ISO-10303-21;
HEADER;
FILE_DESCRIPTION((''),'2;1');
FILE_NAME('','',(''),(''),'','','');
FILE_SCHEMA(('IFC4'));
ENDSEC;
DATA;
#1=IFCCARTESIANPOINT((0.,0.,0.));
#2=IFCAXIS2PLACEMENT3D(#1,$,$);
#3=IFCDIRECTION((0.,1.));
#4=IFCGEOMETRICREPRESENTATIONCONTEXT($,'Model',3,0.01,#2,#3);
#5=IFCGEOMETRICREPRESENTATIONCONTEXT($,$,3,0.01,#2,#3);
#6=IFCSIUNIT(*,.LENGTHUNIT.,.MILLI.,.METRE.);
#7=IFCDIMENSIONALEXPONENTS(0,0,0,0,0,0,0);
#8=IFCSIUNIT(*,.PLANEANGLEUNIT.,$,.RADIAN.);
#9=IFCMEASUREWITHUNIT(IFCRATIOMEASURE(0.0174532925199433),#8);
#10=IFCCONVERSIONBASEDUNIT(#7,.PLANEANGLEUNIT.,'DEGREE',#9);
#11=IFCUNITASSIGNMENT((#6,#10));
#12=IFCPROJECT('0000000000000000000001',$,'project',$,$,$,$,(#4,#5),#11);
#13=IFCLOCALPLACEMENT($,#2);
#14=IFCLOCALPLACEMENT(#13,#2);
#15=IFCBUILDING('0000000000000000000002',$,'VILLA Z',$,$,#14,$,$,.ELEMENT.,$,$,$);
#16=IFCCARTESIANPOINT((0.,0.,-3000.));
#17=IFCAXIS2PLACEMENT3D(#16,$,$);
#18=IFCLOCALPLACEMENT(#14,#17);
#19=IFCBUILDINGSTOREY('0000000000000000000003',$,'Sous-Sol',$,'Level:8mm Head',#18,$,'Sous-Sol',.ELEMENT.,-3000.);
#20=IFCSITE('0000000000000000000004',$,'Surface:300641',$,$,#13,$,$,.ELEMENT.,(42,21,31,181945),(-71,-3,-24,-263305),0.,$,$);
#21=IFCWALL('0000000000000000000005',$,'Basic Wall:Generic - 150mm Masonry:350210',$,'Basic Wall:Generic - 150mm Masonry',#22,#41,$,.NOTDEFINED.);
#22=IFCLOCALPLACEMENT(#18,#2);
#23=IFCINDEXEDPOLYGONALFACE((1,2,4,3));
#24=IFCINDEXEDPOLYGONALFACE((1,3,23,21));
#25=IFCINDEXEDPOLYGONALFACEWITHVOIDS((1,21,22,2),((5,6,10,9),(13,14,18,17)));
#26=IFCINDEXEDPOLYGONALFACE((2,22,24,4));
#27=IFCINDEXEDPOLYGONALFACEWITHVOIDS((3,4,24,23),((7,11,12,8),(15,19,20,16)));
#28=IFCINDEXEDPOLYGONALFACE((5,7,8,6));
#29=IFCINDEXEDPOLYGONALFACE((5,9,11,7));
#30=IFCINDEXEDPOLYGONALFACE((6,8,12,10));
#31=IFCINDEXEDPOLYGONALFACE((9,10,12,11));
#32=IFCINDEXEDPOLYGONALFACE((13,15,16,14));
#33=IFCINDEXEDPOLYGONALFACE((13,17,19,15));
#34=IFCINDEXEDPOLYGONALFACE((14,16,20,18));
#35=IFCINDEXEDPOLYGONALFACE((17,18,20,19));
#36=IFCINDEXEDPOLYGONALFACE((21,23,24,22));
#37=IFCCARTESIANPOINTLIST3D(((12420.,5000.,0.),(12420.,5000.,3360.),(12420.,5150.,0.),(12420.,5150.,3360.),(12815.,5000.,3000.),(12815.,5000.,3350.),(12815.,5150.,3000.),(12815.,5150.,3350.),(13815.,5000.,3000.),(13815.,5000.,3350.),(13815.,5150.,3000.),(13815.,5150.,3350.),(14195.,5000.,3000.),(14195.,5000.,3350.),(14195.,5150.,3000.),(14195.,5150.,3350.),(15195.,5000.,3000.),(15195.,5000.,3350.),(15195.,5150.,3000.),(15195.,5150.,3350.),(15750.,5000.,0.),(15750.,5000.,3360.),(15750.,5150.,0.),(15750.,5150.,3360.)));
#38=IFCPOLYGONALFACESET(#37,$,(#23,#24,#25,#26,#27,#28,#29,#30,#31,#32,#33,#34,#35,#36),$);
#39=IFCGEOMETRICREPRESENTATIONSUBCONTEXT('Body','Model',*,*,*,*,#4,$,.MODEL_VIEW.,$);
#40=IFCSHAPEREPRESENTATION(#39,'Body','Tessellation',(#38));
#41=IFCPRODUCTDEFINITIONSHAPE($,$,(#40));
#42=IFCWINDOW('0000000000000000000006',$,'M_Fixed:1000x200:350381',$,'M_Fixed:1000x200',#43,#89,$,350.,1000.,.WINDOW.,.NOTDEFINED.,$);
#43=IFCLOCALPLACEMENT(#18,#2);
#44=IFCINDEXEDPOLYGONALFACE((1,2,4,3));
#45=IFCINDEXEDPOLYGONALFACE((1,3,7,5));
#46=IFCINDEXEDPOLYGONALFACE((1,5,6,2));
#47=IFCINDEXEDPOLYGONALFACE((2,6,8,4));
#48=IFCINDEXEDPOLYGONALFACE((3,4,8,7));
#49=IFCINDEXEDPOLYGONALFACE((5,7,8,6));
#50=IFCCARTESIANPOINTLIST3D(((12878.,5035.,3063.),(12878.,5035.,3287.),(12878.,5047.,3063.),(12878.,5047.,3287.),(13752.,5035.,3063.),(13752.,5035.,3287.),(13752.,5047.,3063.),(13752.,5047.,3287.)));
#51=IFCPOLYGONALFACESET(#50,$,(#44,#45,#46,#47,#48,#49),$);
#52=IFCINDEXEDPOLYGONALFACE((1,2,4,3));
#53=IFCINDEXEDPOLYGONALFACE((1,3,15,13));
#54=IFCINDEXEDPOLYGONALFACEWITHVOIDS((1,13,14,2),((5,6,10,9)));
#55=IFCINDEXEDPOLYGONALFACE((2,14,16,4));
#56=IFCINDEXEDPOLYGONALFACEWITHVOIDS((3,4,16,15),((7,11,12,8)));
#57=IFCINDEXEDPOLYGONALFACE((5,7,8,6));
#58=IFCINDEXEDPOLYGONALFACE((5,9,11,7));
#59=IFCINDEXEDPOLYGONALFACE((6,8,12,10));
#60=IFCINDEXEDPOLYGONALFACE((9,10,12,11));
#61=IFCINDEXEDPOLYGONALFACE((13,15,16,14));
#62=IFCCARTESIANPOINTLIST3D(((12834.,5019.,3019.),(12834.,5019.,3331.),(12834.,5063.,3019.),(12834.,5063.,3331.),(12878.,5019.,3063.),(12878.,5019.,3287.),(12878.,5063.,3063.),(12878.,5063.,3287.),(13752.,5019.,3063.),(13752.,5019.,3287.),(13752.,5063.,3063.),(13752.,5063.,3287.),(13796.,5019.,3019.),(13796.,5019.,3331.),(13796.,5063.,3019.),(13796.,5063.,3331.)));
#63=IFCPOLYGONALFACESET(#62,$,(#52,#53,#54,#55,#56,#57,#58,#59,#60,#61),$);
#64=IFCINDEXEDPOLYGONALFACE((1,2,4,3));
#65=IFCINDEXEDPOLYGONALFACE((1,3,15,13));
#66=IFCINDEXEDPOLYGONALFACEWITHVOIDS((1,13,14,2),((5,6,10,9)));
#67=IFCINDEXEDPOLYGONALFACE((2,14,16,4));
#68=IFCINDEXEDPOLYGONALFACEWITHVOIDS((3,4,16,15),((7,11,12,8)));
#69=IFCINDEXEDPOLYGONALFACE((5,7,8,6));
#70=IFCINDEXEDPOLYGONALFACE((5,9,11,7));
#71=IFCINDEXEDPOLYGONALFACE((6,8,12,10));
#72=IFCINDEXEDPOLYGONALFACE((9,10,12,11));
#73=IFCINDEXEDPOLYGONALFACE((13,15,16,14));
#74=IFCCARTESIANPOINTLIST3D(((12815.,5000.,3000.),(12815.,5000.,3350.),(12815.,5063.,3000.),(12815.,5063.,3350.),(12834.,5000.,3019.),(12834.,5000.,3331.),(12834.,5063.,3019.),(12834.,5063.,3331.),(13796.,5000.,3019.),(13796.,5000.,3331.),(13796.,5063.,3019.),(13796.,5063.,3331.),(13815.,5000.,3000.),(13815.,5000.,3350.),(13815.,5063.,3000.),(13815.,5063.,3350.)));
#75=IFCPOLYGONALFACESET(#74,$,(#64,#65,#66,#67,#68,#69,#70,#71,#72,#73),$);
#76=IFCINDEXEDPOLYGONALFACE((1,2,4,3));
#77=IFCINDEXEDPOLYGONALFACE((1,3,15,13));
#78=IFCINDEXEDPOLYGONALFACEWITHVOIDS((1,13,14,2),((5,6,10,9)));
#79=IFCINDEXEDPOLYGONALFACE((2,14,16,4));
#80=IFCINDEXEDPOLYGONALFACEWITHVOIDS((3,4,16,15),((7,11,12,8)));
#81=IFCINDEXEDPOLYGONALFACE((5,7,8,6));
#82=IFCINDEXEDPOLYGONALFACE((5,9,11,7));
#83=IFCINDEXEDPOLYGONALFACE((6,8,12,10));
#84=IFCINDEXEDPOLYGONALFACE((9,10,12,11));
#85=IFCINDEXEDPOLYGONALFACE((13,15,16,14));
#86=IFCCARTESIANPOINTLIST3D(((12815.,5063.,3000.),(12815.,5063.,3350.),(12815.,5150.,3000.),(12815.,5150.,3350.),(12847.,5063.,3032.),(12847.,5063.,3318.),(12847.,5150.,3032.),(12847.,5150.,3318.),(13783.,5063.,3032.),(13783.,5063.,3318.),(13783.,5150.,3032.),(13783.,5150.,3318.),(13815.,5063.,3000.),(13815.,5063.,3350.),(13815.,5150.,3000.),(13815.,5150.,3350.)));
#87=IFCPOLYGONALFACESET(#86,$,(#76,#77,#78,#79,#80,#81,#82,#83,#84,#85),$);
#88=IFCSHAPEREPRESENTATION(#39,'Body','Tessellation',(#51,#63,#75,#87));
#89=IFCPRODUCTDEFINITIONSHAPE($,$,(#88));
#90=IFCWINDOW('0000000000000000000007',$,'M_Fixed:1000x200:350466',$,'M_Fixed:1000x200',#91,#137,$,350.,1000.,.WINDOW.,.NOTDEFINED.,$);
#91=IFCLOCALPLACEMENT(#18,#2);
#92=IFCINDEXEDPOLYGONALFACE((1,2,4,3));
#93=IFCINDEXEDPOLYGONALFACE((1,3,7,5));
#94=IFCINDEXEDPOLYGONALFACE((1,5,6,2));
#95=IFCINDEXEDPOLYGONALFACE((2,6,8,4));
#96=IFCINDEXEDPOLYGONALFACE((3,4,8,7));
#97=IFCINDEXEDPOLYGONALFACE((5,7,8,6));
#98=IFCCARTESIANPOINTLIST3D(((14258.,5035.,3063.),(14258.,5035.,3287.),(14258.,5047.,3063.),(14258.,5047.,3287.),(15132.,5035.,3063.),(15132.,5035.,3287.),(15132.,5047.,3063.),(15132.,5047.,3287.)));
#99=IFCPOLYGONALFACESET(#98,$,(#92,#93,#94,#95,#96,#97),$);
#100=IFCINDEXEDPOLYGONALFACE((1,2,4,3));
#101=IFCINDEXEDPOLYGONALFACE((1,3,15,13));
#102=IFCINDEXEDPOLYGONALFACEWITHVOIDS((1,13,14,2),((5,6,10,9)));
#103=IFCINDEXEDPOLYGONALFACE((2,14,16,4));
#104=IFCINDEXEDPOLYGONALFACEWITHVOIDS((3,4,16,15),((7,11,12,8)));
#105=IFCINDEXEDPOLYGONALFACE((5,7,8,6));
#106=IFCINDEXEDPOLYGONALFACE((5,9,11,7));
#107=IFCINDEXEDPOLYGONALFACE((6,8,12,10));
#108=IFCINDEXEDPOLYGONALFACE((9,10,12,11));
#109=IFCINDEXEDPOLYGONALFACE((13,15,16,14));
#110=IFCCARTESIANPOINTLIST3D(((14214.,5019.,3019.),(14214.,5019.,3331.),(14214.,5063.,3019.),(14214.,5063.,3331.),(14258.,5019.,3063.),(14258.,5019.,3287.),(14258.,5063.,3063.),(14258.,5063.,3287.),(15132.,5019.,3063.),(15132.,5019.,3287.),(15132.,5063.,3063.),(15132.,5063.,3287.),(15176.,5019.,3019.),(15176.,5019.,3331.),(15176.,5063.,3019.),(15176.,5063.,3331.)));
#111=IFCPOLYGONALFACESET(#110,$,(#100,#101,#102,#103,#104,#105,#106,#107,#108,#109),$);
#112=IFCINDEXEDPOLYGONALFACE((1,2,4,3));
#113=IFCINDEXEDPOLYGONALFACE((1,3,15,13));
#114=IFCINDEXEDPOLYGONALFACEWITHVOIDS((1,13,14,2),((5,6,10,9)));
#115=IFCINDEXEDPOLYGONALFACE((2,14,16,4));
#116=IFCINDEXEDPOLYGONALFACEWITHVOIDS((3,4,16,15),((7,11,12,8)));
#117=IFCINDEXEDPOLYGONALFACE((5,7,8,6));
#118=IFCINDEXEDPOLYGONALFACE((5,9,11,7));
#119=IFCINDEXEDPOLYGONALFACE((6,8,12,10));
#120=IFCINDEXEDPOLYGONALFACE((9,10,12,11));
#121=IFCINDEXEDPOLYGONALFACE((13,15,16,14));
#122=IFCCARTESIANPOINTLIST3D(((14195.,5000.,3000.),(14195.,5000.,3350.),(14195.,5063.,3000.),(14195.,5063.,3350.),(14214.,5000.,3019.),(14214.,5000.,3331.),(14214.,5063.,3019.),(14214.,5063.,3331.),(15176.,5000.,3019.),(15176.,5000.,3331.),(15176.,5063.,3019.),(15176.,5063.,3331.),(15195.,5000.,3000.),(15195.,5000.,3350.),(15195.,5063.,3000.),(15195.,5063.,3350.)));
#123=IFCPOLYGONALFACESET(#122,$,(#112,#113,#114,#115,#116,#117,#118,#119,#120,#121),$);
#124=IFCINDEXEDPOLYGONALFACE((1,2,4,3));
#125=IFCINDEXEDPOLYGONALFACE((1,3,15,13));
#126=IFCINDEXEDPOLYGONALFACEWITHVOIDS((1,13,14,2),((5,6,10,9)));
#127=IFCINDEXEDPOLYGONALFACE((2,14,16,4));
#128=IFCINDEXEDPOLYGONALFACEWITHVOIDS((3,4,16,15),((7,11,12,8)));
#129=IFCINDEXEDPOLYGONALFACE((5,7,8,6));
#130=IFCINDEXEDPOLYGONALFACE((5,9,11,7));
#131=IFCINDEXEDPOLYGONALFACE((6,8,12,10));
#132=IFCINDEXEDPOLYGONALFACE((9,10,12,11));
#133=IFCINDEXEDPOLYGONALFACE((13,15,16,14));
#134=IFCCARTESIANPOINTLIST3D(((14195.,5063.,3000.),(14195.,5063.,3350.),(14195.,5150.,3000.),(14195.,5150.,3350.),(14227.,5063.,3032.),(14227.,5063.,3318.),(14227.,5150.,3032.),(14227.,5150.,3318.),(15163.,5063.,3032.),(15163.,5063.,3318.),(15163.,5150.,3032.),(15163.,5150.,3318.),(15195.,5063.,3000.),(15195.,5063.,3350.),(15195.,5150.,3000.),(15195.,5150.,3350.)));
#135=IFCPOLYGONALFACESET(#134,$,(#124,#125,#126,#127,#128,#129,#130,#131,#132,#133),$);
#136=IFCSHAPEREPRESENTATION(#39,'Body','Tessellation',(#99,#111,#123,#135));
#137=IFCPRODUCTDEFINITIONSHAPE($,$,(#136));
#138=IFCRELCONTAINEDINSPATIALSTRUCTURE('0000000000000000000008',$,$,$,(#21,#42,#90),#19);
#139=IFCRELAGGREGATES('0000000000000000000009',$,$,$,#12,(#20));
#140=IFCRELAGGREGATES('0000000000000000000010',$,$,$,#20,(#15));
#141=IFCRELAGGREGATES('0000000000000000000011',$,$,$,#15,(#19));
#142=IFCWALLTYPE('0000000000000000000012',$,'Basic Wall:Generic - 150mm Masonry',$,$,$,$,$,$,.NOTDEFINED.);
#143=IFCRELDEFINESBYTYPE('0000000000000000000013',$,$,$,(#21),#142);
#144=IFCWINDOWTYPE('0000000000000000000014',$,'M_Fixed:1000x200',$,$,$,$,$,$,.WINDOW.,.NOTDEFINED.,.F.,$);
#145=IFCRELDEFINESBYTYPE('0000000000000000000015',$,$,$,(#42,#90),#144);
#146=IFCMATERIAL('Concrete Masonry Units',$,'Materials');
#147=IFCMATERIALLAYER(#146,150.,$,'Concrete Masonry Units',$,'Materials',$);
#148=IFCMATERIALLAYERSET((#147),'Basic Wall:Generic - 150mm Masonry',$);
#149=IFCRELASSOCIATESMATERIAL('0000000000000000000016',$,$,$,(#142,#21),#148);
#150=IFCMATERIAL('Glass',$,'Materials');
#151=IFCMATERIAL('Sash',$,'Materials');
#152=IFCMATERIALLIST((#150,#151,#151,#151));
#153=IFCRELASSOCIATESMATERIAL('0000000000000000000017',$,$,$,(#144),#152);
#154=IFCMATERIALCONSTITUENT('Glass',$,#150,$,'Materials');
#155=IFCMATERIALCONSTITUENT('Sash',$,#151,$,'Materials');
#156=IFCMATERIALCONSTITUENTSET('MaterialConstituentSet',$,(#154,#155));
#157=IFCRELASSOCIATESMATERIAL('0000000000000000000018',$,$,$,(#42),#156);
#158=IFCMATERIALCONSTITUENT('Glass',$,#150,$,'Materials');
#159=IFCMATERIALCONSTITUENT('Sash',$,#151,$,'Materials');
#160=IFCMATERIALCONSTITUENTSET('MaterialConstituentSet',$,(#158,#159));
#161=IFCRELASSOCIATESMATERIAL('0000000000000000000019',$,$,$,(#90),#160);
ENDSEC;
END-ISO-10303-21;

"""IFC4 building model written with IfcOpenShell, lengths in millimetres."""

from ifc_helpers import new_model, entity, si_unit, converted_unit, direction, frame, frame_2d, origin, origin_2d_with_axis, place, context, subcontext, project, spatial, polyline, rectangle, outline, extrude, clip, bounded_halfspace, source, transform, mapped, material, material_list, layer, layer_set, layer_usage, constituent, constituent_set, type_object, type_shapes, element, fill, save


model = new_model("IFC4")

# Units and contexts
model_context = context("Model", 3, precision=0.01, world=origin(), true_north=direction((0.0, 1.0)))
context_of_model = context(None, 3, precision=0.01, world=origin(), true_north=direction((0.0, 1.0)))
body_context = subcontext(model_context, "Body", "Model", "MODEL_VIEW")
ifc_project = project(units=[si_unit("LENGTHUNIT", "METRE", prefix="MILLI"), converted_unit("PLANEANGLEUNIT", "DEGREE", entity("IfcRatioMeasure", 0.0174532925199433), si_unit("PLANEANGLEUNIT", "RADIAN"), dimensions=[0, 0, 0, 0, 0, 0, 0])], contexts=[model_context, context_of_model])

# Site, building, storey
site_placement = place(None, origin())
site = spatial("IfcSite", under=ifc_project, at=site_placement, Name="Surface:300641", CompositionType="ELEMENT", RefLatitude=(42, 21, 31, 181945), RefLongitude=(-71, -3, -24, -263305), RefElevation=0.0)
building_placement = place(site_placement, origin())
building = spatial("IfcBuilding", under=site, at=building_placement, Name="VILLA Z", CompositionType="ELEMENT")
storey_placement = place(building_placement, frame((0.0, 0.0, -3000.0)))
storey = spatial("IfcBuildingStorey", under=building, at=storey_placement, Name="Sous-Sol", ObjectType="Level:8mm Head", LongName="Sous-Sol", CompositionType="ELEMENT", Elevation=-3000.0)

# Shared definitions
ifc_material_1 = material(Name="Glass", Category="Materials")
ifc_material_2 = material(Name="Sash", Category="Materials")

# Wall, openings, windows
ifc_material_3 = material(Name="Concrete Masonry Units", Category="Materials")
ifc_layer_1 = layer(ifc_material_3, 150.0, Name="Concrete Masonry Units", Category="Materials")
ifc_layer_set_1 = layer_set([ifc_layer_1], Name="Basic Wall:Generic - 150mm Masonry")
ifc_layer_usage_1 = layer_usage(ifc_layer_set_1, "AXIS2", "NEGATIVE", 75.0)
wall_type_1 = type_object("IfcWallType", Name="Basic Wall:Generic - 150mm Masonry", PredefinedType="NOTDEFINED", material=ifc_layer_set_1)
wall_1_placement = place(storey_placement, frame((12420.0, 5075.0, 0.0)))
wall_1 = element("IfcWall", 1, at=wall_1_placement, inside=storey, type_object=wall_type_1, material=ifc_layer_usage_1, Name="Basic Wall:Generic - 150mm Masonry:350210", ObjectType="Basic Wall:Generic - 150mm Masonry", PredefinedType="NOTDEFINED", context=body_context, shape_type="Clipping", body=[
    clip(extrude(rectangle(XDim=3330.0, YDim=150.0, at=frame_2d((1665.0, 0.0), x_axis=(-1.0, 0.0))), origin(), (0.0, 0.0, 1.0), 3360.0), bounded_halfspace(frame((0.0, -75.0, 3360.0), z_axis=(0.0, 0.0, -1.0), x_axis=(0.0, -1.0, 0.0)), True, frame((0.0, -75.0, 3360.0)), polyline([(0.0, 0.0), (3330.0, 0.0), (3330.0, 150.0), (0.0, 150.0), (0.0, 0.0)]))),
])
opening_1_placement = place(wall_1_placement, frame((2775.0, 75.0, 3000.0)))
opening_1 = element("IfcOpeningElement", 2, at=opening_1_placement, cuts=wall_1, ObjectType="Opening", PredefinedType="OPENING", context=body_context, shape_type="SweptSolid", body=[
    extrude(rectangle(XDim=350.0, YDim=1000.0, at=frame_2d((175.0, 500.0), x_axis=(1.0, 0.0))), frame((0.0, 0.0, 0.0), z_axis=(0.0, -1.0, 0.0), x_axis=(0.0, 0.0, 1.0)), (0.0, 0.0, 1.0), 150.0),
])
opening_2_placement = place(wall_1_placement, frame((1395.0, 75.0, 3000.0)))
opening_2 = element("IfcOpeningElement", 3, at=opening_2_placement, cuts=wall_1, ObjectType="Opening", PredefinedType="OPENING", context=body_context, shape_type="SweptSolid", body=[
    extrude(rectangle(XDim=350.0, YDim=1000.0, at=frame_2d((175.0, 500.0), x_axis=(1.0, 0.0))), frame((0.0, 0.0, 0.0), z_axis=(0.0, -1.0, 0.0), x_axis=(0.0, 0.0, 1.0)), (0.0, 0.0, 1.0), 150.0),
])
ifc_constituent_1 = constituent(ifc_material_1, Name="Glass", Category="Materials")
ifc_constituent_2 = constituent(ifc_material_2, Name="Sash", Category="Materials")
ifc_constituent_set_1 = constituent_set(constituents=[ifc_constituent_1, ifc_constituent_2], Name="MaterialConstituentSet")
ifc_material_list_1 = material_list([ifc_material_1, ifc_material_2, ifc_material_2, ifc_material_2])
window_type_1 = type_object("IfcWindowType", Name="M_Fixed:1000x200", ParameterTakesPrecedence=False, PartitioningType="NOTDEFINED", PredefinedType="WINDOW", material=ifc_material_list_1)
shared_shape_1 = source(origin(), body_context, "Body", "SweptSolid", [
    extrude(rectangle(XDim=12.0, YDim=874.0, at=origin_2d_with_axis()), frame((500.0, 109.0, 63.0), z_axis=(0.0, 0.0, 1.0), x_axis=(0.0, -1.0, 0.0)), (0.0, 0.0, 1.0), 224.0),
    extrude(outline(polyline([(-481.0, -156.0), (481.0, -156.0), (481.0, 156.0), (-481.0, 156.0), (-481.0, -156.0)]), holes=[polyline([(-437.0, -112.0), (-437.0, 112.0), (437.0, 112.0), (437.0, -112.0), (-437.0, -112.0)])]), frame((500.0, 87.0, 175.0), z_axis=(0.0, 1.0, 0.0), x_axis=(1.0, 0.0, 0.0)), (0.0, 0.0, 1.0), 44.0),
    extrude(outline(polyline([(-500.0, -175.0), (500.0, -175.0), (500.0, 175.0), (-500.0, 175.0), (-500.0, -175.0)]), holes=[polyline([(-481.0, -156.0), (-481.0, 156.0), (481.0, 156.0), (481.0, -156.0), (-481.0, -156.0)])]), frame((500.0, 87.0, 175.0), z_axis=(0.0, 1.0, 0.0), x_axis=(1.0, 0.0, 0.0)), (0.0, 0.0, 1.0), 63.0),
    extrude(outline(polyline([(-500.0, -175.0), (500.0, -175.0), (500.0, 175.0), (-500.0, 175.0), (-500.0, -175.0)]), holes=[polyline([(-468.0, -143.0), (-468.0, 143.0), (468.0, 143.0), (468.0, -143.0), (-468.0, -143.0)])]), frame((500.0, 0.0, 175.0), z_axis=(0.0, 1.0, 0.0), x_axis=(1.0, 0.0, 0.0)), (0.0, 0.0, 1.0), 87.0),
])
type_shapes(window_type_1, [shared_shape_1])
window_1_placement = place(opening_2_placement, frame((0.0, 0.0, 0.0), z_axis=(0.0, 0.0, 1.0), x_axis=(-1.0, 0.0, 0.0)))
window_1 = element("IfcWindow", 4, at=window_1_placement, inside=storey, type_object=window_type_1, material=ifc_constituent_set_1, Name="M_Fixed:1000x200:350381", ObjectType="M_Fixed:1000x200", OverallHeight=350.0, OverallWidth=1000.0, PartitioningType="NOTDEFINED", PredefinedType="WINDOW", context=body_context, shape_type="MappedRepresentation", body=[
    mapped(shared_shape_1, transform((0.0, 0.0, 0.0), scale=1.0)),
])
fill(opening_2, window_1)
ifc_constituent_3 = constituent(ifc_material_1, Name="Glass", Category="Materials")
ifc_constituent_4 = constituent(ifc_material_2, Name="Sash", Category="Materials")
ifc_constituent_set_2 = constituent_set(constituents=[ifc_constituent_3, ifc_constituent_4], Name="MaterialConstituentSet")
window_2_placement = place(opening_1_placement, frame((0.0, 0.0, 0.0), z_axis=(0.0, 0.0, 1.0), x_axis=(-1.0, 0.0, 0.0)))
window_2 = element("IfcWindow", 5, at=window_2_placement, inside=storey, type_object=window_type_1, material=ifc_constituent_set_2, Name="M_Fixed:1000x200:350466", ObjectType="M_Fixed:1000x200", OverallHeight=350.0, OverallWidth=1000.0, PartitioningType="NOTDEFINED", PredefinedType="WINDOW", context=body_context, shape_type="MappedRepresentation", body=[
    mapped(shared_shape_1, transform((0.0, 0.0, 0.0), scale=1.0)),
])
fill(opening_1, window_2)

save(model, "model.ifc")
